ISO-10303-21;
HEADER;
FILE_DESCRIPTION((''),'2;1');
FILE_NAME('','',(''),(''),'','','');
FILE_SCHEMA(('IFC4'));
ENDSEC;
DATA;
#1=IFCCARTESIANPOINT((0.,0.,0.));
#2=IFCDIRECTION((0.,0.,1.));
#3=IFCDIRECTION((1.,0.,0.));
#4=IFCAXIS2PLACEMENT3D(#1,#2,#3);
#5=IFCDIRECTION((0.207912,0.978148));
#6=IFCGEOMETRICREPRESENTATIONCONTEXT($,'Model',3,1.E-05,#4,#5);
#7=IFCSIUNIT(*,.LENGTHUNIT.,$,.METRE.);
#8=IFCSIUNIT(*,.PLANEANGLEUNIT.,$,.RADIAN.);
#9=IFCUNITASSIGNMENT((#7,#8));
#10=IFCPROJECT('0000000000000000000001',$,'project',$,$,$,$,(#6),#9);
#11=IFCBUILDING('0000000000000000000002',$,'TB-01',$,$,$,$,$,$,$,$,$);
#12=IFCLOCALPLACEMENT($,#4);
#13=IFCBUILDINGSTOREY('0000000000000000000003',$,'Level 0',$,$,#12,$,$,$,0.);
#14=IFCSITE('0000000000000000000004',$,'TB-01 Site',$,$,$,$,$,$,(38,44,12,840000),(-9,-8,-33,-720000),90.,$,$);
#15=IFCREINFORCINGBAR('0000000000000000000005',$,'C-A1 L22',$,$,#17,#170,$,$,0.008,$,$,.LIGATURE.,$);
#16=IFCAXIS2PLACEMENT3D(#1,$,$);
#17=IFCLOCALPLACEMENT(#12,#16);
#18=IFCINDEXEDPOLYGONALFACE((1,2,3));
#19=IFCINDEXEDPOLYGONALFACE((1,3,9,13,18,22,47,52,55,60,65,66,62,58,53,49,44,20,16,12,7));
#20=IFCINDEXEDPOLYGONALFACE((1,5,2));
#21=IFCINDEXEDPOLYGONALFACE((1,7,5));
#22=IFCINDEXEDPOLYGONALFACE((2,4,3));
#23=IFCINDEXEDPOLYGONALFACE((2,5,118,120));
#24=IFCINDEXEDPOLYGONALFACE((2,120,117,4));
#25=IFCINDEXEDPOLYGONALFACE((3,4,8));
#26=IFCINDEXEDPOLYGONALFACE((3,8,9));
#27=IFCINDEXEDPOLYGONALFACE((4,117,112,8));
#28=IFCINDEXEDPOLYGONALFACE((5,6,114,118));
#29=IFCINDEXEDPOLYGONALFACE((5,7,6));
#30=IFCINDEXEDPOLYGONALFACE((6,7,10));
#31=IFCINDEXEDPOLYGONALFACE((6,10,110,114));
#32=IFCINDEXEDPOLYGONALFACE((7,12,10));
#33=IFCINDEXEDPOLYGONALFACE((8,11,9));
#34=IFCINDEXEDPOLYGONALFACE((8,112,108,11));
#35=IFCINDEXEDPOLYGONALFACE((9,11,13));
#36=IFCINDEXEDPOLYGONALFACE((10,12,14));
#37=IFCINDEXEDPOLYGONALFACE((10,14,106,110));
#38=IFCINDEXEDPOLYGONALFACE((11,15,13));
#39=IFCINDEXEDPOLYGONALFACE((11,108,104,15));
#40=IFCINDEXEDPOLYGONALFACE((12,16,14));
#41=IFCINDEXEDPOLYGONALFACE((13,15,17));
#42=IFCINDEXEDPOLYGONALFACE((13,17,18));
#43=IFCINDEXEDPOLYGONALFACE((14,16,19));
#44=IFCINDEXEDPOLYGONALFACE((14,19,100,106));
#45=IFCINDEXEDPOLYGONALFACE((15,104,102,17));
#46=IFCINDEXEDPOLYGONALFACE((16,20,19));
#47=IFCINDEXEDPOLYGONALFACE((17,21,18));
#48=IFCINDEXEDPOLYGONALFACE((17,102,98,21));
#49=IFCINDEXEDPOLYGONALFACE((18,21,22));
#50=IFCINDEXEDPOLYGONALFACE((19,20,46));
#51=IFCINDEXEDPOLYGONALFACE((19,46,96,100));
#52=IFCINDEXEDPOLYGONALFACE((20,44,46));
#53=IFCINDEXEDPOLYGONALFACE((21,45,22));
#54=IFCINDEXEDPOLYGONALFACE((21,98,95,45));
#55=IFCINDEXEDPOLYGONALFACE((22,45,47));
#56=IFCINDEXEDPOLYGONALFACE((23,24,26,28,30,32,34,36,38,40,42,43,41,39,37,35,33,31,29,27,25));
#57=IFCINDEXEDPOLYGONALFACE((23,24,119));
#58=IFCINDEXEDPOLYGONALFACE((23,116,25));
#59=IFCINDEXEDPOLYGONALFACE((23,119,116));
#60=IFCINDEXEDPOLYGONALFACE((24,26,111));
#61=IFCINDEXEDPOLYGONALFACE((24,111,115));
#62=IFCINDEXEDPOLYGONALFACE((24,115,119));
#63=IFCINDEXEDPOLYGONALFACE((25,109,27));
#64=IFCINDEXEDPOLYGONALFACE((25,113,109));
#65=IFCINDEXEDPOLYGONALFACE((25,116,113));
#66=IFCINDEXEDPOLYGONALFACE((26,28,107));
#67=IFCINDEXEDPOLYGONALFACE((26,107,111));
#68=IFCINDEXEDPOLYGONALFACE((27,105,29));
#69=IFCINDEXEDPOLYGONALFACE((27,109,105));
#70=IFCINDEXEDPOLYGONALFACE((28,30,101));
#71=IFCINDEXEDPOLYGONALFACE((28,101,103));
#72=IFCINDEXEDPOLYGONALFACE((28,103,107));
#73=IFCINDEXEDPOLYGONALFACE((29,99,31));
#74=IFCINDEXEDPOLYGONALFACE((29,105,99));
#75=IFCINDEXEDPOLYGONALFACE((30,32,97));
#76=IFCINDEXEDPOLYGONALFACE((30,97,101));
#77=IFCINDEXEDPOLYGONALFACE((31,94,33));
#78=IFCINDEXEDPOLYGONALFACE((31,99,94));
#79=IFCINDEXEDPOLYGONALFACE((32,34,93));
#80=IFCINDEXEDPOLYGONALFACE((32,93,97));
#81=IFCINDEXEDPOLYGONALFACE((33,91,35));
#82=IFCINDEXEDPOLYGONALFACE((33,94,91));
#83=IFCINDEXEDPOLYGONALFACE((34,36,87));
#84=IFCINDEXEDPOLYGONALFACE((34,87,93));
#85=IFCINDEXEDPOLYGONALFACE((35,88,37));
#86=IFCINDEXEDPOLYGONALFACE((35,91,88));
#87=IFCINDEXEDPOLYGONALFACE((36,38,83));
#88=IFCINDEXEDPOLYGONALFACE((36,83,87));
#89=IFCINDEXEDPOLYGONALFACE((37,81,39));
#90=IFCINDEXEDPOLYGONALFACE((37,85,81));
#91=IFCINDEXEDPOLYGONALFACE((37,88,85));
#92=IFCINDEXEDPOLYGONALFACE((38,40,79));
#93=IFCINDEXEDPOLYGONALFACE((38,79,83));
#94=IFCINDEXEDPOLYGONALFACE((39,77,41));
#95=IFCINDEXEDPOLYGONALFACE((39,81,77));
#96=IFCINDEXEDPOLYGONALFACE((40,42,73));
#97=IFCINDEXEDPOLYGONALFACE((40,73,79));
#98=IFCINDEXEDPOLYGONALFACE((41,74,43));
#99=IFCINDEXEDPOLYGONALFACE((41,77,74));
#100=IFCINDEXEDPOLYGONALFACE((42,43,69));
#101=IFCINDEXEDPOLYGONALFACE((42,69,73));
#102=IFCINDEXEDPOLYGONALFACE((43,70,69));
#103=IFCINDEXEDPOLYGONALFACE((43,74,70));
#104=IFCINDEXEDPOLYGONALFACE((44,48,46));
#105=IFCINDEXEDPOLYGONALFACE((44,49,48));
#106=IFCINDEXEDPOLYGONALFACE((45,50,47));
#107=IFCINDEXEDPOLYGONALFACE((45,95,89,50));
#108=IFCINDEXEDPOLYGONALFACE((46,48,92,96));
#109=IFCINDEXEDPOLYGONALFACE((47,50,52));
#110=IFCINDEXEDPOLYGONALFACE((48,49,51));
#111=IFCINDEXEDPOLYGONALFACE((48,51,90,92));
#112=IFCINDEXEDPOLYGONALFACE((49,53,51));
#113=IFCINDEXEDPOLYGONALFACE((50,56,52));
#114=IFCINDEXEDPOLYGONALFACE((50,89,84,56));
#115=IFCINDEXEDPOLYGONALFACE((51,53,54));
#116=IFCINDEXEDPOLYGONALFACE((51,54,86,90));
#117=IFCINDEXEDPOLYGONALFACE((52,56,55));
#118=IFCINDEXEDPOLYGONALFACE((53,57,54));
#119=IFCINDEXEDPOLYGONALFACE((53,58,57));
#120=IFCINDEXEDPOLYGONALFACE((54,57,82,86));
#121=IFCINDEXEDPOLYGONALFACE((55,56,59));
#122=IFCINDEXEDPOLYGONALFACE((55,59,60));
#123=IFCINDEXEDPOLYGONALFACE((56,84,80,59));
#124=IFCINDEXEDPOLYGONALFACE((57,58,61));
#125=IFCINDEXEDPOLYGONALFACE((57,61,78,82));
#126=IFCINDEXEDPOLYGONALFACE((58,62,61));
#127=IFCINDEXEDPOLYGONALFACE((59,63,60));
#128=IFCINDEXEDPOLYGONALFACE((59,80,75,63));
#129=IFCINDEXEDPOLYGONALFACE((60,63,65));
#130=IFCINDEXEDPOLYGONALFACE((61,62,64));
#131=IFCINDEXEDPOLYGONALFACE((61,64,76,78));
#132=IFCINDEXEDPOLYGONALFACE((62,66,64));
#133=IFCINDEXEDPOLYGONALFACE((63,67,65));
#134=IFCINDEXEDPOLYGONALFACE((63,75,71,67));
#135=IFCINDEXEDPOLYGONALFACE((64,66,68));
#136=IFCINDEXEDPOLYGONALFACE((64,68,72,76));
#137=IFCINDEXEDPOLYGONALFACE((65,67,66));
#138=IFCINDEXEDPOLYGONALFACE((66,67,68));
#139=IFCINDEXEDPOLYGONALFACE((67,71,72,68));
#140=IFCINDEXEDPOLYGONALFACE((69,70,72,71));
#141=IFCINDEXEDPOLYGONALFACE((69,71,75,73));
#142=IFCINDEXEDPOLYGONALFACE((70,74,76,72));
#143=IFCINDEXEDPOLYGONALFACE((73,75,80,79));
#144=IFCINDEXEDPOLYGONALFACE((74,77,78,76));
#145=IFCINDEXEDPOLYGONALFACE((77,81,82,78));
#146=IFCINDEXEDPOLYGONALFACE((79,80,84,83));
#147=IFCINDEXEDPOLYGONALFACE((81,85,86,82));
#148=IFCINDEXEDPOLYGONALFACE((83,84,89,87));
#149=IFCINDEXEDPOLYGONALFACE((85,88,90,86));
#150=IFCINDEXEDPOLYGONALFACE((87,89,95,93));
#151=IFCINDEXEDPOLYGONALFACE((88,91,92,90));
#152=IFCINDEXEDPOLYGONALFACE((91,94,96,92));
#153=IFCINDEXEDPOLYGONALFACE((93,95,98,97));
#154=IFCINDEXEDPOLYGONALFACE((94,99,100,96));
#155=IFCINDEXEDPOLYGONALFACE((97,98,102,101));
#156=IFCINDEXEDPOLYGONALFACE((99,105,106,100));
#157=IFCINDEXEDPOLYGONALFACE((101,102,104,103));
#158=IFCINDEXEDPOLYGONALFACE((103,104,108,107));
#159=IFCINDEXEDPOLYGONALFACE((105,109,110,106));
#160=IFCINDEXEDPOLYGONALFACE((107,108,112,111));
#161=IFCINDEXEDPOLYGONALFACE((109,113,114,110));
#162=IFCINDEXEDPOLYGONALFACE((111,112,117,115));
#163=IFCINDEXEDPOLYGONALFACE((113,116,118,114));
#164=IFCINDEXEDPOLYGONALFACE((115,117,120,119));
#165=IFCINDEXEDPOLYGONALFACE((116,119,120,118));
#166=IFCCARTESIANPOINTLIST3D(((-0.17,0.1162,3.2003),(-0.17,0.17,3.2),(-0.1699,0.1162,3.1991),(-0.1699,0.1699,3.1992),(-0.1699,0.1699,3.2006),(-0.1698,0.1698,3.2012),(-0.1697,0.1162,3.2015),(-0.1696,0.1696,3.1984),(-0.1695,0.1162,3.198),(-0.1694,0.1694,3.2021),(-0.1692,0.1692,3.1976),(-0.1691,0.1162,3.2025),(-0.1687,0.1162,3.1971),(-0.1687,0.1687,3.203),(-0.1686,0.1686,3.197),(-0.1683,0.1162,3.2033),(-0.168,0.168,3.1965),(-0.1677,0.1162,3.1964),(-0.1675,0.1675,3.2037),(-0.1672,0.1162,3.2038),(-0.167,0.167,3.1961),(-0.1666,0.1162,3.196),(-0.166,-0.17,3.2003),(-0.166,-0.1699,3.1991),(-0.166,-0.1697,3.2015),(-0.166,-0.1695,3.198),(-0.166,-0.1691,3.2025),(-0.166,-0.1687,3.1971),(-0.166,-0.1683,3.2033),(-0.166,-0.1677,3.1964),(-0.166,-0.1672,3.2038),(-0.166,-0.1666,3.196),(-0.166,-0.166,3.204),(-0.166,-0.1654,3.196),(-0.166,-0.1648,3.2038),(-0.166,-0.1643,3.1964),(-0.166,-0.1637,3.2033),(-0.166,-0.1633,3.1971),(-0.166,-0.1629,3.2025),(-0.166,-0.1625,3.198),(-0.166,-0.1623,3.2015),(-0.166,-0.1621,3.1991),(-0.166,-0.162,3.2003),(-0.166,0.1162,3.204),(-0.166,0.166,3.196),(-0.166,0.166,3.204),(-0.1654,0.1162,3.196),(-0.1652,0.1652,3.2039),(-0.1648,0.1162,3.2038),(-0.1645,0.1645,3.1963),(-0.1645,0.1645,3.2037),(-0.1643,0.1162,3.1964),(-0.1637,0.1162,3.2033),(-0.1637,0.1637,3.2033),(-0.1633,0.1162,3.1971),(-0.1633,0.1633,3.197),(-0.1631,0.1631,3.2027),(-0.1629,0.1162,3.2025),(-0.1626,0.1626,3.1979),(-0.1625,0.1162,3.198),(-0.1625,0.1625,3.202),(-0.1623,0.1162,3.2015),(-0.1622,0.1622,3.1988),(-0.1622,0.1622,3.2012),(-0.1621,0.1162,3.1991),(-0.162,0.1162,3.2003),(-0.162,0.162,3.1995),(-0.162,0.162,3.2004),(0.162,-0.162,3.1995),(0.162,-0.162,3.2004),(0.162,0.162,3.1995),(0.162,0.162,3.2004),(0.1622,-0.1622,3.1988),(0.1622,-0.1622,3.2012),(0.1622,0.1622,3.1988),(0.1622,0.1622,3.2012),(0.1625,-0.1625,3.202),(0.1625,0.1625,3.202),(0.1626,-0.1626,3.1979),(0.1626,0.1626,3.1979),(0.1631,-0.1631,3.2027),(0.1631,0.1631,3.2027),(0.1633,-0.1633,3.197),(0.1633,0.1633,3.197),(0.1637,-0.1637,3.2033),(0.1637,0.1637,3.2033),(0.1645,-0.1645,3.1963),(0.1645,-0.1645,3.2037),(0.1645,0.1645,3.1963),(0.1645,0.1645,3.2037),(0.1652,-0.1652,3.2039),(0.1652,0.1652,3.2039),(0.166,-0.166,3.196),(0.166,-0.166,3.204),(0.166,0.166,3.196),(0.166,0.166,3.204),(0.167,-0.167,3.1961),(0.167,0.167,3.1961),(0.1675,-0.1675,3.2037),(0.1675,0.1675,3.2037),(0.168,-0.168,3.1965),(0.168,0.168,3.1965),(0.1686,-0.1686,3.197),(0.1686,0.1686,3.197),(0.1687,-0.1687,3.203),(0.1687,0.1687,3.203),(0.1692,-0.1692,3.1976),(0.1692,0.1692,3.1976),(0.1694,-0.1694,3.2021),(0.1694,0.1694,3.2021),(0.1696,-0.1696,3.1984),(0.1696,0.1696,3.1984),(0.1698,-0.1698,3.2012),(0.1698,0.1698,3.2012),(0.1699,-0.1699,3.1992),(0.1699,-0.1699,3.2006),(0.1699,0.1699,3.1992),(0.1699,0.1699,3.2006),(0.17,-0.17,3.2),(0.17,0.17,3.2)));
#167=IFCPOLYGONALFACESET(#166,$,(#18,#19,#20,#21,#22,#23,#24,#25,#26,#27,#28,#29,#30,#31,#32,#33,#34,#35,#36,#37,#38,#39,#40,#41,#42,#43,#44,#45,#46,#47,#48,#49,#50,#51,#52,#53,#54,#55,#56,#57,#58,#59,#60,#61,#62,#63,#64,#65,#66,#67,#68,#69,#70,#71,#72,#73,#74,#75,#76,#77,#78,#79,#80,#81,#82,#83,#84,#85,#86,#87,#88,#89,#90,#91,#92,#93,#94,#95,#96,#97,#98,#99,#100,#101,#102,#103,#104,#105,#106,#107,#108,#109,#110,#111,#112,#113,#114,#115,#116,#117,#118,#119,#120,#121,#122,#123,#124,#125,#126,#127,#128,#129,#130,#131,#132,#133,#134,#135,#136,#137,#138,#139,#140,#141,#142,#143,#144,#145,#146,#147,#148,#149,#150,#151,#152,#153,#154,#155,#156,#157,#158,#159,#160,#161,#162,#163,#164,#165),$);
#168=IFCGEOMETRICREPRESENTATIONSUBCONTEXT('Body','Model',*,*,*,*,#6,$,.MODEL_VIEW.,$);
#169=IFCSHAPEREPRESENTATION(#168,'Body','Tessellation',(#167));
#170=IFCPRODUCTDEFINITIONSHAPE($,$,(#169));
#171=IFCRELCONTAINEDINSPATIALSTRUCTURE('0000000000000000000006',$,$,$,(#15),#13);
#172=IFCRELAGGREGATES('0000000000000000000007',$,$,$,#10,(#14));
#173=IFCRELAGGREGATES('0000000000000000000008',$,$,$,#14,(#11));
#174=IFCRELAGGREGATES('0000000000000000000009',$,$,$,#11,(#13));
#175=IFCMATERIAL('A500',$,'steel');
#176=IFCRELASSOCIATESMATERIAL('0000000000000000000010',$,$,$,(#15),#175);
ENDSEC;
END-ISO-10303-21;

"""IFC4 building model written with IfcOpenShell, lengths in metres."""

from ifc_helpers import new_model, entity, si_unit, direction, origin_with_axes, place, context, subcontext, project, spatial, material, element, save


model = new_model("IFC4")

# Units and contexts
model_context = context("Model", 3, precision=1e-05, world=origin_with_axes(), true_north=direction((0.207912, 0.978148)))
body_context = subcontext(model_context, "Body", "Model", "MODEL_VIEW")
ifc_project = project(units=[si_unit("LENGTHUNIT", "METRE"), si_unit("PLANEANGLEUNIT", "RADIAN")], contexts=[model_context])

# Site, building, storey
site = spatial("IfcSite", under=ifc_project, Name="TB-01 Site", RefLatitude=(38, 44, 12, 840000), RefLongitude=(-9, -8, -33, -720000), RefElevation=90.0)
building = spatial("IfcBuilding", under=site, Name="TB-01")
storey_placement = place(None, origin_with_axes())
storey = spatial("IfcBuildingStorey", under=building, at=storey_placement, Name="Level 0", Elevation=0.0)

# Reinforcing bar
ifc_material_1 = material(Name="A500", Category="steel")
reinforcing_bar_1_placement = place(storey_placement, origin_with_axes())
element("IfcReinforcingBar", 1, at=reinforcing_bar_1_placement, inside=storey, material=ifc_material_1, Name="C-A1 L22", NominalDiameter=0.008, PredefinedType="LIGATURE", context=body_context, shape_type="AdvancedSweptSolid", body=[
    entity("IfcSweptDiskSolid", entity("IfcPolyline", [entity("IfcCartesianPoint", [-0.166, -0.166, 3.2]), entity("IfcCartesianPoint", [0.166, -0.166, 3.2]), entity("IfcCartesianPoint", [0.166, 0.166, 3.2]), entity("IfcCartesianPoint", [-0.166, 0.166, 3.2]), entity("IfcCartesianPoint", [-0.166, 0.1162, 3.2])]), 0.004),
])

save(model, "model.ifc")
